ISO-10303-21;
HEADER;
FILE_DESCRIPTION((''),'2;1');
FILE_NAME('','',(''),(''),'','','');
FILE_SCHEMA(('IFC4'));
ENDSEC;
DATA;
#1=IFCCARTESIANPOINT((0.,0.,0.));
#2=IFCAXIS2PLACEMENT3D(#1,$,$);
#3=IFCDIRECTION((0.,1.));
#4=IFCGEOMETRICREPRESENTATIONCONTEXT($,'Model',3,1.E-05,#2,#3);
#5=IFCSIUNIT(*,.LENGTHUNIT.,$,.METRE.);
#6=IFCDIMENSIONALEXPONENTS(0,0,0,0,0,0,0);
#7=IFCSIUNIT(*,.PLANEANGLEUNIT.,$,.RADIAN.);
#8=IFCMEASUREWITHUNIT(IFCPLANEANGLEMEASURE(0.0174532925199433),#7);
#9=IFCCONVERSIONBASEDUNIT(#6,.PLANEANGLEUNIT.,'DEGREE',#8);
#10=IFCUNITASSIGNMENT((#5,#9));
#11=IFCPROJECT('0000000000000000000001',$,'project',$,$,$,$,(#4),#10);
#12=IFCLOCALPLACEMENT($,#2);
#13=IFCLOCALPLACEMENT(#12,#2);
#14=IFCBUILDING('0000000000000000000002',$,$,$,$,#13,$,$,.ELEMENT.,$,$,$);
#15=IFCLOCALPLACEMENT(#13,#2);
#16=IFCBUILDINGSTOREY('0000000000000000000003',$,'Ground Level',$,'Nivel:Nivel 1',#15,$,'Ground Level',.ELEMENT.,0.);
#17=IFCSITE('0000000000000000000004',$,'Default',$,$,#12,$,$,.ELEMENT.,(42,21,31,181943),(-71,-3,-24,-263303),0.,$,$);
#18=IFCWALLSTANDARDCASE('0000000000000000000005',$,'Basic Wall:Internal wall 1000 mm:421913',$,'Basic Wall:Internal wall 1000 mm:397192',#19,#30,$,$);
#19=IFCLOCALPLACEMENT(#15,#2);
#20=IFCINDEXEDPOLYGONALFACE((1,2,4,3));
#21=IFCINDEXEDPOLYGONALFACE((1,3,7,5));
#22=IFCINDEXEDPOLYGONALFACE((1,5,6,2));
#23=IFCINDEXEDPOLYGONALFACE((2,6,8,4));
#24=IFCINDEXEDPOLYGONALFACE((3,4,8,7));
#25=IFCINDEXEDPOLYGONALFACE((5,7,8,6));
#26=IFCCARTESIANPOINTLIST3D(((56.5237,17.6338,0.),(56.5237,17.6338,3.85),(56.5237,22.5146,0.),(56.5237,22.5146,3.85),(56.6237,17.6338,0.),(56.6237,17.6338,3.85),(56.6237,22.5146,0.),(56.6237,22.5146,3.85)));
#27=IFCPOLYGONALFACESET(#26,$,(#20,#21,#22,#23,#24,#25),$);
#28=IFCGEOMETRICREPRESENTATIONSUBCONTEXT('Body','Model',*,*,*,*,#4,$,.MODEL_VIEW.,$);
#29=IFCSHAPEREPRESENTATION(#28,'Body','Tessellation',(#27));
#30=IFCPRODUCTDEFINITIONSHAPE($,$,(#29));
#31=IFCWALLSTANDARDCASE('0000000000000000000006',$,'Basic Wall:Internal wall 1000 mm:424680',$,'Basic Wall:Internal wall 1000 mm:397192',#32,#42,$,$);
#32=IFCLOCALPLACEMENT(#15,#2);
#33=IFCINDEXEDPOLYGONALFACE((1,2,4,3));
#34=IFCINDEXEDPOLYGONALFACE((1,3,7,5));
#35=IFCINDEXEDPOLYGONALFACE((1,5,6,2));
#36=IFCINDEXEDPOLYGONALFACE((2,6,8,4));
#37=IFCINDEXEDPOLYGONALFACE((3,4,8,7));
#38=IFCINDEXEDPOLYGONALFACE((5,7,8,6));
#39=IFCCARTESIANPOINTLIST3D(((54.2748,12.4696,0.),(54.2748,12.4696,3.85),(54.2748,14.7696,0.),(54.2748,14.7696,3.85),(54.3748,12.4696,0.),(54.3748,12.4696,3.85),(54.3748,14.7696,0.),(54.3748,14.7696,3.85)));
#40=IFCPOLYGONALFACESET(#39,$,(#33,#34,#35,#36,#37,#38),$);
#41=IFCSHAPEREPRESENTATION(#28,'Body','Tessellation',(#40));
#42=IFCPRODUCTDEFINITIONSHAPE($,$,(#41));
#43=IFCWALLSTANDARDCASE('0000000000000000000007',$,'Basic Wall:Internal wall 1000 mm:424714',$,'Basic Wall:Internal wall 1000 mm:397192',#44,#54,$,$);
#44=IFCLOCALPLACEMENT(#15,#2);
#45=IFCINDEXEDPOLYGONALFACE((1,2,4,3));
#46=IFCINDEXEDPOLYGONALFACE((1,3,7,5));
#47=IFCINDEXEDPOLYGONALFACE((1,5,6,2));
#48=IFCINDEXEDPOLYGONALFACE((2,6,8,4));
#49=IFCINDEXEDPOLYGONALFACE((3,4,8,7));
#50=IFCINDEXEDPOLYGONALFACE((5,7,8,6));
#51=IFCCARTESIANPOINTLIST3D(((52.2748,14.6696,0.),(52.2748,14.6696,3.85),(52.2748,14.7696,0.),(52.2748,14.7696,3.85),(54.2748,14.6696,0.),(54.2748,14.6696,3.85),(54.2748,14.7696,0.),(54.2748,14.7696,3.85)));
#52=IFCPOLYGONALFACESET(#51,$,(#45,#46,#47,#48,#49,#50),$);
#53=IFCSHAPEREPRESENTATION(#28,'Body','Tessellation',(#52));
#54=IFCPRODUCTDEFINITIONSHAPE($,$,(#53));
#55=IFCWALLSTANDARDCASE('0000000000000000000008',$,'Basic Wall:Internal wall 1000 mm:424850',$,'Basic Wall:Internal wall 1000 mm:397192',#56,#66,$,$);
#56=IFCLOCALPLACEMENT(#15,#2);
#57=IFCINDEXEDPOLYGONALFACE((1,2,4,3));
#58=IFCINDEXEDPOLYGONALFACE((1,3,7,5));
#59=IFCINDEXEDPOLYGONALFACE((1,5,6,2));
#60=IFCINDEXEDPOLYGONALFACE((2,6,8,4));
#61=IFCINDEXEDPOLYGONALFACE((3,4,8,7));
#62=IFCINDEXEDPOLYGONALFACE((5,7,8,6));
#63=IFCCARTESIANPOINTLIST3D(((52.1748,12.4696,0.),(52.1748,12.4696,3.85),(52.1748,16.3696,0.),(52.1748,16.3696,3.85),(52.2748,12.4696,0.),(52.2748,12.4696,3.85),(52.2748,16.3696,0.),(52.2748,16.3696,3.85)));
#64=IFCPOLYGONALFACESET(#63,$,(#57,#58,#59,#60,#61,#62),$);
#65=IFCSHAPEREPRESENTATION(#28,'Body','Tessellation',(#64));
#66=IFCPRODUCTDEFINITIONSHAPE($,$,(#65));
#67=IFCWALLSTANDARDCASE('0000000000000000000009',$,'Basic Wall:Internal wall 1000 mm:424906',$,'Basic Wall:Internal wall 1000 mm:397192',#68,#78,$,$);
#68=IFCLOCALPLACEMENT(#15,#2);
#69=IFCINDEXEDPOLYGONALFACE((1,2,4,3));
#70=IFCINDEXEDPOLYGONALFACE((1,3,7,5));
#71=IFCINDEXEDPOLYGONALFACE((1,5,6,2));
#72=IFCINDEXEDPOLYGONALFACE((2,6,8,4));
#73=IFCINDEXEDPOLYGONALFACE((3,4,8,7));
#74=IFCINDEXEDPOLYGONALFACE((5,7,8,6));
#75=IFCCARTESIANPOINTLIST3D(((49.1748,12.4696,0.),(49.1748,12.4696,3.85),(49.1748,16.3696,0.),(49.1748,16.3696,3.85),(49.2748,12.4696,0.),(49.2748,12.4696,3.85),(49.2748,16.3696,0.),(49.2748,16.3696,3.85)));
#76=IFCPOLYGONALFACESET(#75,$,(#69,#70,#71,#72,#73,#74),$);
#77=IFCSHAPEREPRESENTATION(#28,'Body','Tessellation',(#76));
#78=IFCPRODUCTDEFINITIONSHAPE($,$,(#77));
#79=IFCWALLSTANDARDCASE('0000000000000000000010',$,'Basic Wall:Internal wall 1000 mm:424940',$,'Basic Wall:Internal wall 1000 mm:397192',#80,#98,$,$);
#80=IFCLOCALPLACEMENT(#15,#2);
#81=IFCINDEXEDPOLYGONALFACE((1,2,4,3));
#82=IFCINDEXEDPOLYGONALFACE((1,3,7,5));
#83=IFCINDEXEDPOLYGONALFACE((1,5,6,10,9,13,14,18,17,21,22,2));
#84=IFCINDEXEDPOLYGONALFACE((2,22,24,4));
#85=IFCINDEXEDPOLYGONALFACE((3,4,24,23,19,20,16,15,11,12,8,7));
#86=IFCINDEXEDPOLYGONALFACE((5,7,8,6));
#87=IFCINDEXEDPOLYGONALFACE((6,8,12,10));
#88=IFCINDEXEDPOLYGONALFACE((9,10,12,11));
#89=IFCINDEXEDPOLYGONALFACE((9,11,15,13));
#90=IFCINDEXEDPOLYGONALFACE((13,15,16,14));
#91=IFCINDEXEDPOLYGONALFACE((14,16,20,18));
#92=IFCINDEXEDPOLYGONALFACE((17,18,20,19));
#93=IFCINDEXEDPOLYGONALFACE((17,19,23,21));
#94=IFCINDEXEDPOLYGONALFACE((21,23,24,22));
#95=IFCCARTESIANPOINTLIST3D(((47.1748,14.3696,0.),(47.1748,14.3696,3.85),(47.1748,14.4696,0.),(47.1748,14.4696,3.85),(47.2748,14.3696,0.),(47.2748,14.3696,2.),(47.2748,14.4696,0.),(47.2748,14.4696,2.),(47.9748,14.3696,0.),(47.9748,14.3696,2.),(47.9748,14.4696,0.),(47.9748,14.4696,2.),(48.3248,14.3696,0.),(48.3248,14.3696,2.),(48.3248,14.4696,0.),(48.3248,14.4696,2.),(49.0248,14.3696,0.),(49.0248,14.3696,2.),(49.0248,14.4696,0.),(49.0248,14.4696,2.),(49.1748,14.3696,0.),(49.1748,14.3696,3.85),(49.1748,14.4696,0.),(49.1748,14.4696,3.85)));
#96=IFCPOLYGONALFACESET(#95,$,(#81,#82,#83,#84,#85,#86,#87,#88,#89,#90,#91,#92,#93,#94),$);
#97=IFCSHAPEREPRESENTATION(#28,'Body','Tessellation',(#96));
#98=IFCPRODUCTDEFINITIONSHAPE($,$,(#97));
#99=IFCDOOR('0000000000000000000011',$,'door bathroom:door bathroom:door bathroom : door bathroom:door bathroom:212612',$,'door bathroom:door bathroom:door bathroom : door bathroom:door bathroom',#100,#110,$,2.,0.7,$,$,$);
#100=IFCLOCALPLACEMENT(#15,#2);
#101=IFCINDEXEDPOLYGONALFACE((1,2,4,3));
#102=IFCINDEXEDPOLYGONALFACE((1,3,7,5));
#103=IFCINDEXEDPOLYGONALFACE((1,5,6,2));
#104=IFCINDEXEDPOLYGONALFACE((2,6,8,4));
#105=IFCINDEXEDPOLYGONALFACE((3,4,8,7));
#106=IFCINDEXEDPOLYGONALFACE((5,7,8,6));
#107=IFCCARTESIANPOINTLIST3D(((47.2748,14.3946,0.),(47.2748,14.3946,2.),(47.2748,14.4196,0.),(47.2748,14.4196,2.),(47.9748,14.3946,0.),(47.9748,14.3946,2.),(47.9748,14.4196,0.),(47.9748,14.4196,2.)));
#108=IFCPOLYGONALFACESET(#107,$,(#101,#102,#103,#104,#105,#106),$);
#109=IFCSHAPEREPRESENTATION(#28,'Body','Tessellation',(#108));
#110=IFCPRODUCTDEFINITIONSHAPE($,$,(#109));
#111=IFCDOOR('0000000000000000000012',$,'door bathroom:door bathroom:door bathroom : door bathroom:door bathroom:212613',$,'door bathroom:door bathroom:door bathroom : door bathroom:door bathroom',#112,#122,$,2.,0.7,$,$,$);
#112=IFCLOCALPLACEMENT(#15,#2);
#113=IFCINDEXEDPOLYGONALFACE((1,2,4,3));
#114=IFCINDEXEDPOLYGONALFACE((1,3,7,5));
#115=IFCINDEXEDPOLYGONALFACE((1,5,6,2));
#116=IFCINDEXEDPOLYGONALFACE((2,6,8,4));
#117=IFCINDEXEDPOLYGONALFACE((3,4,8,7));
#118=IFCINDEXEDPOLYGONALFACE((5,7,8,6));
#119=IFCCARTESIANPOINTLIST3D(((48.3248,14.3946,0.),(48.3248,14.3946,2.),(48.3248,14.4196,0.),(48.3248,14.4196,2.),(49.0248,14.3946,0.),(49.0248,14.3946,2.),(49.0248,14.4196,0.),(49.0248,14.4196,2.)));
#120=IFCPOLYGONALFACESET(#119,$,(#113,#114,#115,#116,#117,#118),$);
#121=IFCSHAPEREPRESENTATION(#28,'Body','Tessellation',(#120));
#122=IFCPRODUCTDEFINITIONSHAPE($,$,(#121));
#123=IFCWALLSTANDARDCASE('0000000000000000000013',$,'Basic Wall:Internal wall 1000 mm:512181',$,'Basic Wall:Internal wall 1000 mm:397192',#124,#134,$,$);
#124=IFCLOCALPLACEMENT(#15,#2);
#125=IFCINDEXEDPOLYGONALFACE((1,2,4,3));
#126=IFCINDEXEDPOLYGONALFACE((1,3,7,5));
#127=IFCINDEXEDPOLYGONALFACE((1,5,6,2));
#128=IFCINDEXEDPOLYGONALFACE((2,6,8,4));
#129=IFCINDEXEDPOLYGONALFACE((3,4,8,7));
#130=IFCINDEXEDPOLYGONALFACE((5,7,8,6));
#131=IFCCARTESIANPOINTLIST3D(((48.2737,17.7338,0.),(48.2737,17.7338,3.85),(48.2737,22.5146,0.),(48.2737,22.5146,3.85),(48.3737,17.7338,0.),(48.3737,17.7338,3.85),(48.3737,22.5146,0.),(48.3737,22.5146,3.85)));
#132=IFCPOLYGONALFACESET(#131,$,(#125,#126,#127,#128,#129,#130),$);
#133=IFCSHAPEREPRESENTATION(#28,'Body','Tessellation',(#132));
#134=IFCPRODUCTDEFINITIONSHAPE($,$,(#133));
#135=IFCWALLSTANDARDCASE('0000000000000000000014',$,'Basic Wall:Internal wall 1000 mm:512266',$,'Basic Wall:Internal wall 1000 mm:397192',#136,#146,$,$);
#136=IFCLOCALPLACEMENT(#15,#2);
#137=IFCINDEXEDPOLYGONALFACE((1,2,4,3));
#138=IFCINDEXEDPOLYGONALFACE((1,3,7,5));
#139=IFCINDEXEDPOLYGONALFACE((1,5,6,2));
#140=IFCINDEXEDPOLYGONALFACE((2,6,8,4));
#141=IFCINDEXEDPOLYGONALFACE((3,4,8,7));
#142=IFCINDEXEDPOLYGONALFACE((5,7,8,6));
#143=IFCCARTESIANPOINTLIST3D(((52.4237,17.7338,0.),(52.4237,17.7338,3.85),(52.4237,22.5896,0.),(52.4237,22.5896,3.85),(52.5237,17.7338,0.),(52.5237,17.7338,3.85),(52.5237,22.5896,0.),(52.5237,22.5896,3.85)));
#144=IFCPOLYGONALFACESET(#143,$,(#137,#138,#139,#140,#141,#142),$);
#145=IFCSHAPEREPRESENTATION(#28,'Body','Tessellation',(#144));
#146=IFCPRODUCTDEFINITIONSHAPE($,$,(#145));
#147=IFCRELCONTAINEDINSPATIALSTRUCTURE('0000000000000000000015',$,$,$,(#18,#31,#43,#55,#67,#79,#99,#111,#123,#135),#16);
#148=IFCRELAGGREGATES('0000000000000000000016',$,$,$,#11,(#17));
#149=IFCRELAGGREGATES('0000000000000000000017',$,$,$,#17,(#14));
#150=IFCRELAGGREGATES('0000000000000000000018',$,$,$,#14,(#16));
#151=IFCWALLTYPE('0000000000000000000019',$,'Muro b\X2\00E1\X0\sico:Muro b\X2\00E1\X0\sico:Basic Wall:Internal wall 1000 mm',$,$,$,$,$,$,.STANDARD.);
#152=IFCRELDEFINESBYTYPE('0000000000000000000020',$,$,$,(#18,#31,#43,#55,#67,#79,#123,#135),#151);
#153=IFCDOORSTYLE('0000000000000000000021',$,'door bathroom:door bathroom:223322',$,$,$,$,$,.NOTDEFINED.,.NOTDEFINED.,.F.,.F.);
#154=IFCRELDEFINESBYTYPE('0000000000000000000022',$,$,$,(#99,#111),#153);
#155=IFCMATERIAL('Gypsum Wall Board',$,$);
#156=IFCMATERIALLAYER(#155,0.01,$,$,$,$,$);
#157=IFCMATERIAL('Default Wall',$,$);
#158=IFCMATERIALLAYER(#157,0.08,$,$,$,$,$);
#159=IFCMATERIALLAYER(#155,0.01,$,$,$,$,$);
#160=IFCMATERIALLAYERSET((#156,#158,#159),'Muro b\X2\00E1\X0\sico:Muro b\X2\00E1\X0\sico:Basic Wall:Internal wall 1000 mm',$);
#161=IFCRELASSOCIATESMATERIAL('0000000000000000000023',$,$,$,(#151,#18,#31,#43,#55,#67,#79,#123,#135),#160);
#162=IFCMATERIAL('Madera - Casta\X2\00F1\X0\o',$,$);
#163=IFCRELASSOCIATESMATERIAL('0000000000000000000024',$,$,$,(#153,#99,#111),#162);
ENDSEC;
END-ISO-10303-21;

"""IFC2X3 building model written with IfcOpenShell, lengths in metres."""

from ifc_helpers import new_model, entity, si_unit, converted_unit, direction, frame, frame_2d, origin, origin_2d_with_axis, place, context, subcontext, project, spatial, rectangle, extrude, source, transform, mapped, material, layer, layer_set, layer_usage, type_object, type_shapes, element, fill, save


model = new_model("IFC2X3")

# Units and contexts
model_context = context("Model", 3, precision=1e-05, world=origin(), true_north=direction((0.0, 1.0)))
body_context = subcontext(model_context, "Body", "Model", "MODEL_VIEW")
ifc_project = project(units=[si_unit("LENGTHUNIT", "METRE"), converted_unit("PLANEANGLEUNIT", "DEGREE", entity("IfcPlaneAngleMeasure", 0.0174532925199433), si_unit("PLANEANGLEUNIT", "RADIAN"), dimensions=[0, 0, 0, 0, 0, 0, 0])], contexts=[model_context])

# Site, building, storey
site_placement = place(None, origin())
site = spatial("IfcSite", under=ifc_project, at=site_placement, Name="Default", CompositionType="ELEMENT", RefLatitude=(42, 21, 31, 181943), RefLongitude=(-71, -3, -24, -263303), RefElevation=0.0)
building_placement = place(site_placement, origin())
building = spatial("IfcBuilding", under=site, at=building_placement, CompositionType="ELEMENT")
storey_placement = place(building_placement, origin())
storey = spatial("IfcBuildingStorey", under=building, at=storey_placement, Name="Ground Level", ObjectType="Nivel:Nivel 1", LongName="Ground Level", CompositionType="ELEMENT", Elevation=0.0)

# Wall
ifc_material_1 = material(Name="Gypsum Wall Board")
ifc_layer_1 = layer(ifc_material_1, 0.01)
ifc_material_2 = material(Name="Default Wall")
ifc_layer_2 = layer(ifc_material_2, 0.08)
ifc_layer_3 = layer(ifc_material_1, 0.01)
ifc_layer_set = layer_set([ifc_layer_1, ifc_layer_2, ifc_layer_3], Name="Muro básico:Muro básico:Basic Wall:Internal wall 1000 mm")
ifc_layer_usage_1 = layer_usage(ifc_layer_set, "AXIS2", "NEGATIVE", 0.05)
wall_type = type_object("IfcWallType", Name="Muro básico:Muro básico:Basic Wall:Internal wall 1000 mm", PredefinedType="STANDARD", material=ifc_layer_set)
wall_1_placement = place(storey_placement, frame((56.5737, 22.5146, 0.0), z_axis=(0.0, 0.0, 1.0), x_axis=(0.0, -1.0, 0.0)))
element("IfcWallStandardCase", 1, at=wall_1_placement, inside=storey, type_object=wall_type, material=ifc_layer_usage_1, Name="Basic Wall:Internal wall 1000 mm:421913", ObjectType="Basic Wall:Internal wall 1000 mm:397192", context=body_context, shape_type="SweptSolid", body=[
    extrude(rectangle(XDim=4.8809, YDim=0.1, at=frame_2d((2.4404, 0.0), x_axis=(-1.0, 0.0))), origin(), (0.0, 0.0, 1.0), 3.85),
])

# Shared definitions
ifc_material_3 = material(Name="Madera - Castaño")

# Walls
ifc_layer_usage_2 = layer_usage(ifc_layer_set, "AXIS2", "NEGATIVE", 0.05)
wall_2_placement = place(storey_placement, frame((54.3248, 12.4696, 0.0), z_axis=(0.0, 0.0, 1.0), x_axis=(0.0, 1.0, 0.0)))
element("IfcWallStandardCase", 2, at=wall_2_placement, inside=storey, type_object=wall_type, material=ifc_layer_usage_2, Name="Basic Wall:Internal wall 1000 mm:424680", ObjectType="Basic Wall:Internal wall 1000 mm:397192", context=body_context, shape_type="SweptSolid", body=[
    extrude(rectangle(XDim=2.3, YDim=0.1, at=frame_2d((1.15, 0.0), x_axis=(-1.0, 0.0))), origin(), (0.0, 0.0, 1.0), 3.85),
])
ifc_layer_usage_3 = layer_usage(ifc_layer_set, "AXIS2", "NEGATIVE", 0.05)
wall_3_placement = place(storey_placement, frame((54.2748, 14.7196, 0.0), z_axis=(0.0, 0.0, 1.0), x_axis=(-1.0, 0.0, 0.0)))
element("IfcWallStandardCase", 3, at=wall_3_placement, inside=storey, type_object=wall_type, material=ifc_layer_usage_3, Name="Basic Wall:Internal wall 1000 mm:424714", ObjectType="Basic Wall:Internal wall 1000 mm:397192", context=body_context, shape_type="SweptSolid", body=[
    extrude(rectangle(XDim=2.0, YDim=0.1, at=frame_2d((1.0, 0.0), x_axis=(-1.0, 0.0))), origin(), (0.0, 0.0, 1.0), 3.85),
])
ifc_layer_usage_4 = layer_usage(ifc_layer_set, "AXIS2", "NEGATIVE", 0.05)
wall_4_placement = place(storey_placement, frame((52.2248, 12.4696, 0.0), z_axis=(0.0, 0.0, 1.0), x_axis=(0.0, 1.0, 0.0)))
element("IfcWallStandardCase", 4, at=wall_4_placement, inside=storey, type_object=wall_type, material=ifc_layer_usage_4, Name="Basic Wall:Internal wall 1000 mm:424850", ObjectType="Basic Wall:Internal wall 1000 mm:397192", context=body_context, shape_type="SweptSolid", body=[
    extrude(rectangle(XDim=3.9, YDim=0.1, at=frame_2d((1.95, 0.0), x_axis=(-1.0, 0.0))), origin(), (0.0, 0.0, 1.0), 3.85),
])
ifc_layer_usage_5 = layer_usage(ifc_layer_set, "AXIS2", "NEGATIVE", 0.05)
wall_5_placement = place(storey_placement, frame((49.2248, 12.4696, 0.0), z_axis=(0.0, 0.0, 1.0), x_axis=(0.0, 1.0, 0.0)))
element("IfcWallStandardCase", 5, at=wall_5_placement, inside=storey, type_object=wall_type, material=ifc_layer_usage_5, Name="Basic Wall:Internal wall 1000 mm:424906", ObjectType="Basic Wall:Internal wall 1000 mm:397192", context=body_context, shape_type="SweptSolid", body=[
    extrude(rectangle(XDim=3.9, YDim=0.1, at=frame_2d((1.95, 0.0), x_axis=(-1.0, 0.0))), origin(), (0.0, 0.0, 1.0), 3.85),
])

# Wall, openings, doors
ifc_layer_usage_6 = layer_usage(ifc_layer_set, "AXIS2", "NEGATIVE", 0.05)
wall_6_placement = place(storey_placement, frame((49.1748, 14.4196, 0.0), z_axis=(0.0, 0.0, 1.0), x_axis=(-1.0, 0.0, 0.0)))
wall_6 = element("IfcWallStandardCase", 6, at=wall_6_placement, inside=storey, type_object=wall_type, material=ifc_layer_usage_6, Name="Basic Wall:Internal wall 1000 mm:424940", ObjectType="Basic Wall:Internal wall 1000 mm:397192", context=body_context, shape_type="SweptSolid", body=[
    extrude(rectangle(XDim=2.0, YDim=0.1, at=frame_2d((1.0, 0.0), x_axis=(1.0, 0.0))), origin(), (0.0, 0.0, 1.0), 3.85),
])
opening_1_placement = place(wall_6_placement, frame((49.1748, 14.4196, 0.0), z_axis=(0.0, 0.0, 1.0), x_axis=(-1.0, 0.0, 0.0)))
opening_1 = element("IfcOpeningElement", 7, at=opening_1_placement, cuts=wall_6, ObjectType="Opening", context=body_context, shape_type="SweptSolid", body=[
    extrude(rectangle(XDim=2.0, YDim=0.7, at=frame_2d((0.0, 0.0), x_axis=(0.0, 1.0))), frame((47.6248, 14.4717, 1.0), z_axis=(0.0, -1.0, 0.0), x_axis=(1.0, 0.0, 0.0)), (0.0, 0.0, 1.0), 0.104),
])
opening_2_placement = place(wall_6_placement, frame((49.1748, 14.4196, 0.0), z_axis=(0.0, 0.0, 1.0), x_axis=(-1.0, 0.0, 0.0)))
opening_2 = element("IfcOpeningElement", 8, at=opening_2_placement, cuts=wall_6, ObjectType="Opening", context=body_context, shape_type="SweptSolid", body=[
    extrude(rectangle(XDim=2.0, YDim=0.7, at=frame_2d((0.0, 0.0), x_axis=(0.0, 1.0))), frame((48.6748, 14.4717, 1.0), z_axis=(0.0, -1.0, 0.0), x_axis=(1.0, 0.0, 0.0)), (0.0, 0.0, 1.0), 0.104),
])
door_style_1 = type_object("IfcDoorStyle", Name="door bathroom:door bathroom:223322", ConstructionType="NOTDEFINED", OperationType="NOTDEFINED", ParameterTakesPrecedence=False, Sizeable=False, material=ifc_material_3)
shared_shape_1 = source(origin(), body_context, "Body", "SweptSolid", [
    extrude(rectangle(XDim=0.7, YDim=0.025, at=origin_2d_with_axis()), frame((0.35, 0.0395, 0.0)), (0.0, 0.0, 1.0), 2.0),
])
type_shapes(door_style_1, [shared_shape_1])
door_1_placement = place(opening_1_placement, frame((47.2748, 14.3676, 0.0)))
door_1 = element("IfcDoor", 9, at=door_1_placement, inside=storey, type_object=door_style_1, material=ifc_material_3, Name="door bathroom:door bathroom:door bathroom : door bathroom:door bathroom:212612", ObjectType="door bathroom:door bathroom:door bathroom : door bathroom:door bathroom", OverallHeight=2.0, OverallWidth=0.7, context=body_context, shape_type="MappedRepresentation", body=[
    mapped(shared_shape_1, transform((0.0, 0.0, 0.0), scale=1.0)),
])
fill(opening_1, door_1)
door_2_placement = place(opening_2_placement, frame((48.3248, 14.3676, 0.0)))
door_2 = element("IfcDoor", 10, at=door_2_placement, inside=storey, type_object=door_style_1, material=ifc_material_3, Name="door bathroom:door bathroom:door bathroom : door bathroom:door bathroom:212613", ObjectType="door bathroom:door bathroom:door bathroom : door bathroom:door bathroom", OverallHeight=2.0, OverallWidth=0.7, context=body_context, shape_type="MappedRepresentation", body=[
    mapped(shared_shape_1, transform((0.0, 0.0, 0.0), scale=1.0)),
])
fill(opening_2, door_2)

# Walls
ifc_layer_usage_7 = layer_usage(ifc_layer_set, "AXIS2", "NEGATIVE", 0.05)
wall_7_placement = place(storey_placement, frame((48.3237, 17.7338, 0.0), z_axis=(0.0, 0.0, 1.0), x_axis=(0.0, 1.0, 0.0)))
element("IfcWallStandardCase", 11, at=wall_7_placement, inside=storey, type_object=wall_type, material=ifc_layer_usage_7, Name="Basic Wall:Internal wall 1000 mm:512181", ObjectType="Basic Wall:Internal wall 1000 mm:397192", context=body_context, shape_type="SweptSolid", body=[
    extrude(rectangle(XDim=4.7809, YDim=0.1, at=frame_2d((2.3904, 0.0), x_axis=(-1.0, 0.0))), origin(), (0.0, 0.0, 1.0), 3.85),
])
ifc_layer_usage_8 = layer_usage(ifc_layer_set, "AXIS2", "NEGATIVE", 0.05)
wall_8_placement = place(storey_placement, frame((52.4737, 17.7338, 0.0), z_axis=(0.0, 0.0, 1.0), x_axis=(0.0, 1.0, 0.0)))
element("IfcWallStandardCase", 12, at=wall_8_placement, inside=storey, type_object=wall_type, material=ifc_layer_usage_8, Name="Basic Wall:Internal wall 1000 mm:512266", ObjectType="Basic Wall:Internal wall 1000 mm:397192", context=body_context, shape_type="SweptSolid", body=[
    extrude(rectangle(XDim=4.8559, YDim=0.1, at=frame_2d((2.4279, 0.0), x_axis=(-1.0, 0.0))), origin(), (0.0, 0.0, 1.0), 3.85),
])

save(model, "model.ifc")
